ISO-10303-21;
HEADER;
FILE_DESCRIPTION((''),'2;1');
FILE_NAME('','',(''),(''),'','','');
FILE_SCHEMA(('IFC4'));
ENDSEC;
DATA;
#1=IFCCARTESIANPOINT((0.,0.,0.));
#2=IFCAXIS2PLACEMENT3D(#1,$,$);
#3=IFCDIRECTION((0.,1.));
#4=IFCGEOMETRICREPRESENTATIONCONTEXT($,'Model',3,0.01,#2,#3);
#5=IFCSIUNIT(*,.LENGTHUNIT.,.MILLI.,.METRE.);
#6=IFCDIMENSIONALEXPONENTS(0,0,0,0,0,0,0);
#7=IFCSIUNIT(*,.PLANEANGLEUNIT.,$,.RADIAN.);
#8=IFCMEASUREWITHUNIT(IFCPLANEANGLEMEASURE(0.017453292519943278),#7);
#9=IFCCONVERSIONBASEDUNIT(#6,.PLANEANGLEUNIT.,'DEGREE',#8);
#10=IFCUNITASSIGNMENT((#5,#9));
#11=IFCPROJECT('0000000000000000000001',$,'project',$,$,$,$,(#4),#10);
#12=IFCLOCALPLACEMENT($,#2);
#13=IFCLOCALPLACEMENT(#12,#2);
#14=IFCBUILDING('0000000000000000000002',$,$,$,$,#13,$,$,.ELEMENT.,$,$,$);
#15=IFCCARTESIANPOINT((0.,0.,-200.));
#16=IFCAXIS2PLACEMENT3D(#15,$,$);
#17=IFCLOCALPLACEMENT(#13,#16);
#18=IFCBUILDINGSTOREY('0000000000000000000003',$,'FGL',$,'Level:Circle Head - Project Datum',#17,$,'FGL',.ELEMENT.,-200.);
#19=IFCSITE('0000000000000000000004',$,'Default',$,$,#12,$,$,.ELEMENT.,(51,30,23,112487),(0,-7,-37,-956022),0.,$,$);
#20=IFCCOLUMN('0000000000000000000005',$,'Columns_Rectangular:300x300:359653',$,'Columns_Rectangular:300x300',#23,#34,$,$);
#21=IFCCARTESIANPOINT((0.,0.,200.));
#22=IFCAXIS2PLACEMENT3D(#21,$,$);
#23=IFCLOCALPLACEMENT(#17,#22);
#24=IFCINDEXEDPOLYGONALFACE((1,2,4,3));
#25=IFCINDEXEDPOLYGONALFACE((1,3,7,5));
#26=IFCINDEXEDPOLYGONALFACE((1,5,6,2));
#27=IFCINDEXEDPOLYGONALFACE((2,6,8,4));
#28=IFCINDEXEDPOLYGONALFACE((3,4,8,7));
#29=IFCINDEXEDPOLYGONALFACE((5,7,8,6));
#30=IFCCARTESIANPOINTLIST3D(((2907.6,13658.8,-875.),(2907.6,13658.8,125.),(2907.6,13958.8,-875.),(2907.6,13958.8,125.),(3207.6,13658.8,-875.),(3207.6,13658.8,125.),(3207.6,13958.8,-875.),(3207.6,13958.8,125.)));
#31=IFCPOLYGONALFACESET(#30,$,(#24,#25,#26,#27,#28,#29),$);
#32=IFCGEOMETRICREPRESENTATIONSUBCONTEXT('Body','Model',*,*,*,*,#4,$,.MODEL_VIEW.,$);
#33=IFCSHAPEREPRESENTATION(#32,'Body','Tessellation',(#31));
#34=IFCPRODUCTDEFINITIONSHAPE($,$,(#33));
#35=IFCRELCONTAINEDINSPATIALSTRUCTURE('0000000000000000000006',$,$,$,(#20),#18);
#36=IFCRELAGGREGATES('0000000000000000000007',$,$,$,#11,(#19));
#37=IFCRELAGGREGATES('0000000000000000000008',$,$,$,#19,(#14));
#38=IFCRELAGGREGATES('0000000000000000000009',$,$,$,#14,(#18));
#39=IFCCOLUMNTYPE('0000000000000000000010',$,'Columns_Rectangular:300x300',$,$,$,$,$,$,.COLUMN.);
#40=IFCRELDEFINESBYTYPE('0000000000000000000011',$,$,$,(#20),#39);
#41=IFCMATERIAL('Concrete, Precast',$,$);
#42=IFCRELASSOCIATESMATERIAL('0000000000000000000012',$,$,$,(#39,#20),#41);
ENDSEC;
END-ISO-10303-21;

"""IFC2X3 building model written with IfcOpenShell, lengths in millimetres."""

from ifc_helpers import new_model, entity, si_unit, converted_unit, direction, frame, frame_2d, origin, place, context, subcontext, project, spatial, rectangle, extrude, source, transform, mapped, material, type_object, type_shapes, element, save


model = new_model("IFC2X3")

# Units and contexts
model_context = context("Model", 3, precision=0.01, world=origin(), true_north=direction((0.0, 1.0)))
body_context = subcontext(model_context, "Body", "Model", "MODEL_VIEW")
ifc_project = project(units=[si_unit("LENGTHUNIT", "METRE", prefix="MILLI"), converted_unit("PLANEANGLEUNIT", "DEGREE", entity("IfcPlaneAngleMeasure", 0.017453292519943278), si_unit("PLANEANGLEUNIT", "RADIAN"), dimensions=[0, 0, 0, 0, 0, 0, 0])], contexts=[model_context])

# Site, building, storey
site_placement = place(None, origin())
site = spatial("IfcSite", under=ifc_project, at=site_placement, Name="Default", CompositionType="ELEMENT", RefLatitude=(51, 30, 23, 112487), RefLongitude=(0, -7, -37, -956022), RefElevation=0.0)
building_placement = place(site_placement, origin())
building = spatial("IfcBuilding", under=site, at=building_placement, CompositionType="ELEMENT")
storey_placement = place(building_placement, frame((0.0, 0.0, -200.0)))
storey = spatial("IfcBuildingStorey", under=building, at=storey_placement, Name="FGL", ObjectType="Level:Circle Head - Project Datum", LongName="FGL", CompositionType="ELEMENT", Elevation=-200.0)

# Column
ifc_material_1 = material(Name="Concrete, Precast")
column_type_1 = type_object("IfcColumnType", Name="Columns_Rectangular:300x300", PredefinedType="COLUMN", material=ifc_material_1)
shared_shape_1 = source(origin(), body_context, "Body", "SweptSolid", [
    extrude(rectangle(XDim=300.0, YDim=300.0, at=frame_2d((0.0, 0.0), x_axis=(1.0, 0.0))), frame((3057.6, 13808.8, -875.0), z_axis=(0.0, 0.0, 1.0), x_axis=(-1.0, 0.0, 0.0)), (0.0, 0.0, 1.0), 1000.0),
])
type_shapes(column_type_1, [shared_shape_1])
column_1_placement = place(storey_placement, frame((0.0, 0.0, 200.0)))
element("IfcColumn", 1, at=column_1_placement, inside=storey, type_object=column_type_1, material=ifc_material_1, Name="Columns_Rectangular:300x300:359653", ObjectType="Columns_Rectangular:300x300", context=body_context, shape_type="MappedRepresentation", body=[
    mapped(shared_shape_1, transform((0.0, 0.0, 0.0), scale=1.0)),
])

save(model, "model.ifc")
